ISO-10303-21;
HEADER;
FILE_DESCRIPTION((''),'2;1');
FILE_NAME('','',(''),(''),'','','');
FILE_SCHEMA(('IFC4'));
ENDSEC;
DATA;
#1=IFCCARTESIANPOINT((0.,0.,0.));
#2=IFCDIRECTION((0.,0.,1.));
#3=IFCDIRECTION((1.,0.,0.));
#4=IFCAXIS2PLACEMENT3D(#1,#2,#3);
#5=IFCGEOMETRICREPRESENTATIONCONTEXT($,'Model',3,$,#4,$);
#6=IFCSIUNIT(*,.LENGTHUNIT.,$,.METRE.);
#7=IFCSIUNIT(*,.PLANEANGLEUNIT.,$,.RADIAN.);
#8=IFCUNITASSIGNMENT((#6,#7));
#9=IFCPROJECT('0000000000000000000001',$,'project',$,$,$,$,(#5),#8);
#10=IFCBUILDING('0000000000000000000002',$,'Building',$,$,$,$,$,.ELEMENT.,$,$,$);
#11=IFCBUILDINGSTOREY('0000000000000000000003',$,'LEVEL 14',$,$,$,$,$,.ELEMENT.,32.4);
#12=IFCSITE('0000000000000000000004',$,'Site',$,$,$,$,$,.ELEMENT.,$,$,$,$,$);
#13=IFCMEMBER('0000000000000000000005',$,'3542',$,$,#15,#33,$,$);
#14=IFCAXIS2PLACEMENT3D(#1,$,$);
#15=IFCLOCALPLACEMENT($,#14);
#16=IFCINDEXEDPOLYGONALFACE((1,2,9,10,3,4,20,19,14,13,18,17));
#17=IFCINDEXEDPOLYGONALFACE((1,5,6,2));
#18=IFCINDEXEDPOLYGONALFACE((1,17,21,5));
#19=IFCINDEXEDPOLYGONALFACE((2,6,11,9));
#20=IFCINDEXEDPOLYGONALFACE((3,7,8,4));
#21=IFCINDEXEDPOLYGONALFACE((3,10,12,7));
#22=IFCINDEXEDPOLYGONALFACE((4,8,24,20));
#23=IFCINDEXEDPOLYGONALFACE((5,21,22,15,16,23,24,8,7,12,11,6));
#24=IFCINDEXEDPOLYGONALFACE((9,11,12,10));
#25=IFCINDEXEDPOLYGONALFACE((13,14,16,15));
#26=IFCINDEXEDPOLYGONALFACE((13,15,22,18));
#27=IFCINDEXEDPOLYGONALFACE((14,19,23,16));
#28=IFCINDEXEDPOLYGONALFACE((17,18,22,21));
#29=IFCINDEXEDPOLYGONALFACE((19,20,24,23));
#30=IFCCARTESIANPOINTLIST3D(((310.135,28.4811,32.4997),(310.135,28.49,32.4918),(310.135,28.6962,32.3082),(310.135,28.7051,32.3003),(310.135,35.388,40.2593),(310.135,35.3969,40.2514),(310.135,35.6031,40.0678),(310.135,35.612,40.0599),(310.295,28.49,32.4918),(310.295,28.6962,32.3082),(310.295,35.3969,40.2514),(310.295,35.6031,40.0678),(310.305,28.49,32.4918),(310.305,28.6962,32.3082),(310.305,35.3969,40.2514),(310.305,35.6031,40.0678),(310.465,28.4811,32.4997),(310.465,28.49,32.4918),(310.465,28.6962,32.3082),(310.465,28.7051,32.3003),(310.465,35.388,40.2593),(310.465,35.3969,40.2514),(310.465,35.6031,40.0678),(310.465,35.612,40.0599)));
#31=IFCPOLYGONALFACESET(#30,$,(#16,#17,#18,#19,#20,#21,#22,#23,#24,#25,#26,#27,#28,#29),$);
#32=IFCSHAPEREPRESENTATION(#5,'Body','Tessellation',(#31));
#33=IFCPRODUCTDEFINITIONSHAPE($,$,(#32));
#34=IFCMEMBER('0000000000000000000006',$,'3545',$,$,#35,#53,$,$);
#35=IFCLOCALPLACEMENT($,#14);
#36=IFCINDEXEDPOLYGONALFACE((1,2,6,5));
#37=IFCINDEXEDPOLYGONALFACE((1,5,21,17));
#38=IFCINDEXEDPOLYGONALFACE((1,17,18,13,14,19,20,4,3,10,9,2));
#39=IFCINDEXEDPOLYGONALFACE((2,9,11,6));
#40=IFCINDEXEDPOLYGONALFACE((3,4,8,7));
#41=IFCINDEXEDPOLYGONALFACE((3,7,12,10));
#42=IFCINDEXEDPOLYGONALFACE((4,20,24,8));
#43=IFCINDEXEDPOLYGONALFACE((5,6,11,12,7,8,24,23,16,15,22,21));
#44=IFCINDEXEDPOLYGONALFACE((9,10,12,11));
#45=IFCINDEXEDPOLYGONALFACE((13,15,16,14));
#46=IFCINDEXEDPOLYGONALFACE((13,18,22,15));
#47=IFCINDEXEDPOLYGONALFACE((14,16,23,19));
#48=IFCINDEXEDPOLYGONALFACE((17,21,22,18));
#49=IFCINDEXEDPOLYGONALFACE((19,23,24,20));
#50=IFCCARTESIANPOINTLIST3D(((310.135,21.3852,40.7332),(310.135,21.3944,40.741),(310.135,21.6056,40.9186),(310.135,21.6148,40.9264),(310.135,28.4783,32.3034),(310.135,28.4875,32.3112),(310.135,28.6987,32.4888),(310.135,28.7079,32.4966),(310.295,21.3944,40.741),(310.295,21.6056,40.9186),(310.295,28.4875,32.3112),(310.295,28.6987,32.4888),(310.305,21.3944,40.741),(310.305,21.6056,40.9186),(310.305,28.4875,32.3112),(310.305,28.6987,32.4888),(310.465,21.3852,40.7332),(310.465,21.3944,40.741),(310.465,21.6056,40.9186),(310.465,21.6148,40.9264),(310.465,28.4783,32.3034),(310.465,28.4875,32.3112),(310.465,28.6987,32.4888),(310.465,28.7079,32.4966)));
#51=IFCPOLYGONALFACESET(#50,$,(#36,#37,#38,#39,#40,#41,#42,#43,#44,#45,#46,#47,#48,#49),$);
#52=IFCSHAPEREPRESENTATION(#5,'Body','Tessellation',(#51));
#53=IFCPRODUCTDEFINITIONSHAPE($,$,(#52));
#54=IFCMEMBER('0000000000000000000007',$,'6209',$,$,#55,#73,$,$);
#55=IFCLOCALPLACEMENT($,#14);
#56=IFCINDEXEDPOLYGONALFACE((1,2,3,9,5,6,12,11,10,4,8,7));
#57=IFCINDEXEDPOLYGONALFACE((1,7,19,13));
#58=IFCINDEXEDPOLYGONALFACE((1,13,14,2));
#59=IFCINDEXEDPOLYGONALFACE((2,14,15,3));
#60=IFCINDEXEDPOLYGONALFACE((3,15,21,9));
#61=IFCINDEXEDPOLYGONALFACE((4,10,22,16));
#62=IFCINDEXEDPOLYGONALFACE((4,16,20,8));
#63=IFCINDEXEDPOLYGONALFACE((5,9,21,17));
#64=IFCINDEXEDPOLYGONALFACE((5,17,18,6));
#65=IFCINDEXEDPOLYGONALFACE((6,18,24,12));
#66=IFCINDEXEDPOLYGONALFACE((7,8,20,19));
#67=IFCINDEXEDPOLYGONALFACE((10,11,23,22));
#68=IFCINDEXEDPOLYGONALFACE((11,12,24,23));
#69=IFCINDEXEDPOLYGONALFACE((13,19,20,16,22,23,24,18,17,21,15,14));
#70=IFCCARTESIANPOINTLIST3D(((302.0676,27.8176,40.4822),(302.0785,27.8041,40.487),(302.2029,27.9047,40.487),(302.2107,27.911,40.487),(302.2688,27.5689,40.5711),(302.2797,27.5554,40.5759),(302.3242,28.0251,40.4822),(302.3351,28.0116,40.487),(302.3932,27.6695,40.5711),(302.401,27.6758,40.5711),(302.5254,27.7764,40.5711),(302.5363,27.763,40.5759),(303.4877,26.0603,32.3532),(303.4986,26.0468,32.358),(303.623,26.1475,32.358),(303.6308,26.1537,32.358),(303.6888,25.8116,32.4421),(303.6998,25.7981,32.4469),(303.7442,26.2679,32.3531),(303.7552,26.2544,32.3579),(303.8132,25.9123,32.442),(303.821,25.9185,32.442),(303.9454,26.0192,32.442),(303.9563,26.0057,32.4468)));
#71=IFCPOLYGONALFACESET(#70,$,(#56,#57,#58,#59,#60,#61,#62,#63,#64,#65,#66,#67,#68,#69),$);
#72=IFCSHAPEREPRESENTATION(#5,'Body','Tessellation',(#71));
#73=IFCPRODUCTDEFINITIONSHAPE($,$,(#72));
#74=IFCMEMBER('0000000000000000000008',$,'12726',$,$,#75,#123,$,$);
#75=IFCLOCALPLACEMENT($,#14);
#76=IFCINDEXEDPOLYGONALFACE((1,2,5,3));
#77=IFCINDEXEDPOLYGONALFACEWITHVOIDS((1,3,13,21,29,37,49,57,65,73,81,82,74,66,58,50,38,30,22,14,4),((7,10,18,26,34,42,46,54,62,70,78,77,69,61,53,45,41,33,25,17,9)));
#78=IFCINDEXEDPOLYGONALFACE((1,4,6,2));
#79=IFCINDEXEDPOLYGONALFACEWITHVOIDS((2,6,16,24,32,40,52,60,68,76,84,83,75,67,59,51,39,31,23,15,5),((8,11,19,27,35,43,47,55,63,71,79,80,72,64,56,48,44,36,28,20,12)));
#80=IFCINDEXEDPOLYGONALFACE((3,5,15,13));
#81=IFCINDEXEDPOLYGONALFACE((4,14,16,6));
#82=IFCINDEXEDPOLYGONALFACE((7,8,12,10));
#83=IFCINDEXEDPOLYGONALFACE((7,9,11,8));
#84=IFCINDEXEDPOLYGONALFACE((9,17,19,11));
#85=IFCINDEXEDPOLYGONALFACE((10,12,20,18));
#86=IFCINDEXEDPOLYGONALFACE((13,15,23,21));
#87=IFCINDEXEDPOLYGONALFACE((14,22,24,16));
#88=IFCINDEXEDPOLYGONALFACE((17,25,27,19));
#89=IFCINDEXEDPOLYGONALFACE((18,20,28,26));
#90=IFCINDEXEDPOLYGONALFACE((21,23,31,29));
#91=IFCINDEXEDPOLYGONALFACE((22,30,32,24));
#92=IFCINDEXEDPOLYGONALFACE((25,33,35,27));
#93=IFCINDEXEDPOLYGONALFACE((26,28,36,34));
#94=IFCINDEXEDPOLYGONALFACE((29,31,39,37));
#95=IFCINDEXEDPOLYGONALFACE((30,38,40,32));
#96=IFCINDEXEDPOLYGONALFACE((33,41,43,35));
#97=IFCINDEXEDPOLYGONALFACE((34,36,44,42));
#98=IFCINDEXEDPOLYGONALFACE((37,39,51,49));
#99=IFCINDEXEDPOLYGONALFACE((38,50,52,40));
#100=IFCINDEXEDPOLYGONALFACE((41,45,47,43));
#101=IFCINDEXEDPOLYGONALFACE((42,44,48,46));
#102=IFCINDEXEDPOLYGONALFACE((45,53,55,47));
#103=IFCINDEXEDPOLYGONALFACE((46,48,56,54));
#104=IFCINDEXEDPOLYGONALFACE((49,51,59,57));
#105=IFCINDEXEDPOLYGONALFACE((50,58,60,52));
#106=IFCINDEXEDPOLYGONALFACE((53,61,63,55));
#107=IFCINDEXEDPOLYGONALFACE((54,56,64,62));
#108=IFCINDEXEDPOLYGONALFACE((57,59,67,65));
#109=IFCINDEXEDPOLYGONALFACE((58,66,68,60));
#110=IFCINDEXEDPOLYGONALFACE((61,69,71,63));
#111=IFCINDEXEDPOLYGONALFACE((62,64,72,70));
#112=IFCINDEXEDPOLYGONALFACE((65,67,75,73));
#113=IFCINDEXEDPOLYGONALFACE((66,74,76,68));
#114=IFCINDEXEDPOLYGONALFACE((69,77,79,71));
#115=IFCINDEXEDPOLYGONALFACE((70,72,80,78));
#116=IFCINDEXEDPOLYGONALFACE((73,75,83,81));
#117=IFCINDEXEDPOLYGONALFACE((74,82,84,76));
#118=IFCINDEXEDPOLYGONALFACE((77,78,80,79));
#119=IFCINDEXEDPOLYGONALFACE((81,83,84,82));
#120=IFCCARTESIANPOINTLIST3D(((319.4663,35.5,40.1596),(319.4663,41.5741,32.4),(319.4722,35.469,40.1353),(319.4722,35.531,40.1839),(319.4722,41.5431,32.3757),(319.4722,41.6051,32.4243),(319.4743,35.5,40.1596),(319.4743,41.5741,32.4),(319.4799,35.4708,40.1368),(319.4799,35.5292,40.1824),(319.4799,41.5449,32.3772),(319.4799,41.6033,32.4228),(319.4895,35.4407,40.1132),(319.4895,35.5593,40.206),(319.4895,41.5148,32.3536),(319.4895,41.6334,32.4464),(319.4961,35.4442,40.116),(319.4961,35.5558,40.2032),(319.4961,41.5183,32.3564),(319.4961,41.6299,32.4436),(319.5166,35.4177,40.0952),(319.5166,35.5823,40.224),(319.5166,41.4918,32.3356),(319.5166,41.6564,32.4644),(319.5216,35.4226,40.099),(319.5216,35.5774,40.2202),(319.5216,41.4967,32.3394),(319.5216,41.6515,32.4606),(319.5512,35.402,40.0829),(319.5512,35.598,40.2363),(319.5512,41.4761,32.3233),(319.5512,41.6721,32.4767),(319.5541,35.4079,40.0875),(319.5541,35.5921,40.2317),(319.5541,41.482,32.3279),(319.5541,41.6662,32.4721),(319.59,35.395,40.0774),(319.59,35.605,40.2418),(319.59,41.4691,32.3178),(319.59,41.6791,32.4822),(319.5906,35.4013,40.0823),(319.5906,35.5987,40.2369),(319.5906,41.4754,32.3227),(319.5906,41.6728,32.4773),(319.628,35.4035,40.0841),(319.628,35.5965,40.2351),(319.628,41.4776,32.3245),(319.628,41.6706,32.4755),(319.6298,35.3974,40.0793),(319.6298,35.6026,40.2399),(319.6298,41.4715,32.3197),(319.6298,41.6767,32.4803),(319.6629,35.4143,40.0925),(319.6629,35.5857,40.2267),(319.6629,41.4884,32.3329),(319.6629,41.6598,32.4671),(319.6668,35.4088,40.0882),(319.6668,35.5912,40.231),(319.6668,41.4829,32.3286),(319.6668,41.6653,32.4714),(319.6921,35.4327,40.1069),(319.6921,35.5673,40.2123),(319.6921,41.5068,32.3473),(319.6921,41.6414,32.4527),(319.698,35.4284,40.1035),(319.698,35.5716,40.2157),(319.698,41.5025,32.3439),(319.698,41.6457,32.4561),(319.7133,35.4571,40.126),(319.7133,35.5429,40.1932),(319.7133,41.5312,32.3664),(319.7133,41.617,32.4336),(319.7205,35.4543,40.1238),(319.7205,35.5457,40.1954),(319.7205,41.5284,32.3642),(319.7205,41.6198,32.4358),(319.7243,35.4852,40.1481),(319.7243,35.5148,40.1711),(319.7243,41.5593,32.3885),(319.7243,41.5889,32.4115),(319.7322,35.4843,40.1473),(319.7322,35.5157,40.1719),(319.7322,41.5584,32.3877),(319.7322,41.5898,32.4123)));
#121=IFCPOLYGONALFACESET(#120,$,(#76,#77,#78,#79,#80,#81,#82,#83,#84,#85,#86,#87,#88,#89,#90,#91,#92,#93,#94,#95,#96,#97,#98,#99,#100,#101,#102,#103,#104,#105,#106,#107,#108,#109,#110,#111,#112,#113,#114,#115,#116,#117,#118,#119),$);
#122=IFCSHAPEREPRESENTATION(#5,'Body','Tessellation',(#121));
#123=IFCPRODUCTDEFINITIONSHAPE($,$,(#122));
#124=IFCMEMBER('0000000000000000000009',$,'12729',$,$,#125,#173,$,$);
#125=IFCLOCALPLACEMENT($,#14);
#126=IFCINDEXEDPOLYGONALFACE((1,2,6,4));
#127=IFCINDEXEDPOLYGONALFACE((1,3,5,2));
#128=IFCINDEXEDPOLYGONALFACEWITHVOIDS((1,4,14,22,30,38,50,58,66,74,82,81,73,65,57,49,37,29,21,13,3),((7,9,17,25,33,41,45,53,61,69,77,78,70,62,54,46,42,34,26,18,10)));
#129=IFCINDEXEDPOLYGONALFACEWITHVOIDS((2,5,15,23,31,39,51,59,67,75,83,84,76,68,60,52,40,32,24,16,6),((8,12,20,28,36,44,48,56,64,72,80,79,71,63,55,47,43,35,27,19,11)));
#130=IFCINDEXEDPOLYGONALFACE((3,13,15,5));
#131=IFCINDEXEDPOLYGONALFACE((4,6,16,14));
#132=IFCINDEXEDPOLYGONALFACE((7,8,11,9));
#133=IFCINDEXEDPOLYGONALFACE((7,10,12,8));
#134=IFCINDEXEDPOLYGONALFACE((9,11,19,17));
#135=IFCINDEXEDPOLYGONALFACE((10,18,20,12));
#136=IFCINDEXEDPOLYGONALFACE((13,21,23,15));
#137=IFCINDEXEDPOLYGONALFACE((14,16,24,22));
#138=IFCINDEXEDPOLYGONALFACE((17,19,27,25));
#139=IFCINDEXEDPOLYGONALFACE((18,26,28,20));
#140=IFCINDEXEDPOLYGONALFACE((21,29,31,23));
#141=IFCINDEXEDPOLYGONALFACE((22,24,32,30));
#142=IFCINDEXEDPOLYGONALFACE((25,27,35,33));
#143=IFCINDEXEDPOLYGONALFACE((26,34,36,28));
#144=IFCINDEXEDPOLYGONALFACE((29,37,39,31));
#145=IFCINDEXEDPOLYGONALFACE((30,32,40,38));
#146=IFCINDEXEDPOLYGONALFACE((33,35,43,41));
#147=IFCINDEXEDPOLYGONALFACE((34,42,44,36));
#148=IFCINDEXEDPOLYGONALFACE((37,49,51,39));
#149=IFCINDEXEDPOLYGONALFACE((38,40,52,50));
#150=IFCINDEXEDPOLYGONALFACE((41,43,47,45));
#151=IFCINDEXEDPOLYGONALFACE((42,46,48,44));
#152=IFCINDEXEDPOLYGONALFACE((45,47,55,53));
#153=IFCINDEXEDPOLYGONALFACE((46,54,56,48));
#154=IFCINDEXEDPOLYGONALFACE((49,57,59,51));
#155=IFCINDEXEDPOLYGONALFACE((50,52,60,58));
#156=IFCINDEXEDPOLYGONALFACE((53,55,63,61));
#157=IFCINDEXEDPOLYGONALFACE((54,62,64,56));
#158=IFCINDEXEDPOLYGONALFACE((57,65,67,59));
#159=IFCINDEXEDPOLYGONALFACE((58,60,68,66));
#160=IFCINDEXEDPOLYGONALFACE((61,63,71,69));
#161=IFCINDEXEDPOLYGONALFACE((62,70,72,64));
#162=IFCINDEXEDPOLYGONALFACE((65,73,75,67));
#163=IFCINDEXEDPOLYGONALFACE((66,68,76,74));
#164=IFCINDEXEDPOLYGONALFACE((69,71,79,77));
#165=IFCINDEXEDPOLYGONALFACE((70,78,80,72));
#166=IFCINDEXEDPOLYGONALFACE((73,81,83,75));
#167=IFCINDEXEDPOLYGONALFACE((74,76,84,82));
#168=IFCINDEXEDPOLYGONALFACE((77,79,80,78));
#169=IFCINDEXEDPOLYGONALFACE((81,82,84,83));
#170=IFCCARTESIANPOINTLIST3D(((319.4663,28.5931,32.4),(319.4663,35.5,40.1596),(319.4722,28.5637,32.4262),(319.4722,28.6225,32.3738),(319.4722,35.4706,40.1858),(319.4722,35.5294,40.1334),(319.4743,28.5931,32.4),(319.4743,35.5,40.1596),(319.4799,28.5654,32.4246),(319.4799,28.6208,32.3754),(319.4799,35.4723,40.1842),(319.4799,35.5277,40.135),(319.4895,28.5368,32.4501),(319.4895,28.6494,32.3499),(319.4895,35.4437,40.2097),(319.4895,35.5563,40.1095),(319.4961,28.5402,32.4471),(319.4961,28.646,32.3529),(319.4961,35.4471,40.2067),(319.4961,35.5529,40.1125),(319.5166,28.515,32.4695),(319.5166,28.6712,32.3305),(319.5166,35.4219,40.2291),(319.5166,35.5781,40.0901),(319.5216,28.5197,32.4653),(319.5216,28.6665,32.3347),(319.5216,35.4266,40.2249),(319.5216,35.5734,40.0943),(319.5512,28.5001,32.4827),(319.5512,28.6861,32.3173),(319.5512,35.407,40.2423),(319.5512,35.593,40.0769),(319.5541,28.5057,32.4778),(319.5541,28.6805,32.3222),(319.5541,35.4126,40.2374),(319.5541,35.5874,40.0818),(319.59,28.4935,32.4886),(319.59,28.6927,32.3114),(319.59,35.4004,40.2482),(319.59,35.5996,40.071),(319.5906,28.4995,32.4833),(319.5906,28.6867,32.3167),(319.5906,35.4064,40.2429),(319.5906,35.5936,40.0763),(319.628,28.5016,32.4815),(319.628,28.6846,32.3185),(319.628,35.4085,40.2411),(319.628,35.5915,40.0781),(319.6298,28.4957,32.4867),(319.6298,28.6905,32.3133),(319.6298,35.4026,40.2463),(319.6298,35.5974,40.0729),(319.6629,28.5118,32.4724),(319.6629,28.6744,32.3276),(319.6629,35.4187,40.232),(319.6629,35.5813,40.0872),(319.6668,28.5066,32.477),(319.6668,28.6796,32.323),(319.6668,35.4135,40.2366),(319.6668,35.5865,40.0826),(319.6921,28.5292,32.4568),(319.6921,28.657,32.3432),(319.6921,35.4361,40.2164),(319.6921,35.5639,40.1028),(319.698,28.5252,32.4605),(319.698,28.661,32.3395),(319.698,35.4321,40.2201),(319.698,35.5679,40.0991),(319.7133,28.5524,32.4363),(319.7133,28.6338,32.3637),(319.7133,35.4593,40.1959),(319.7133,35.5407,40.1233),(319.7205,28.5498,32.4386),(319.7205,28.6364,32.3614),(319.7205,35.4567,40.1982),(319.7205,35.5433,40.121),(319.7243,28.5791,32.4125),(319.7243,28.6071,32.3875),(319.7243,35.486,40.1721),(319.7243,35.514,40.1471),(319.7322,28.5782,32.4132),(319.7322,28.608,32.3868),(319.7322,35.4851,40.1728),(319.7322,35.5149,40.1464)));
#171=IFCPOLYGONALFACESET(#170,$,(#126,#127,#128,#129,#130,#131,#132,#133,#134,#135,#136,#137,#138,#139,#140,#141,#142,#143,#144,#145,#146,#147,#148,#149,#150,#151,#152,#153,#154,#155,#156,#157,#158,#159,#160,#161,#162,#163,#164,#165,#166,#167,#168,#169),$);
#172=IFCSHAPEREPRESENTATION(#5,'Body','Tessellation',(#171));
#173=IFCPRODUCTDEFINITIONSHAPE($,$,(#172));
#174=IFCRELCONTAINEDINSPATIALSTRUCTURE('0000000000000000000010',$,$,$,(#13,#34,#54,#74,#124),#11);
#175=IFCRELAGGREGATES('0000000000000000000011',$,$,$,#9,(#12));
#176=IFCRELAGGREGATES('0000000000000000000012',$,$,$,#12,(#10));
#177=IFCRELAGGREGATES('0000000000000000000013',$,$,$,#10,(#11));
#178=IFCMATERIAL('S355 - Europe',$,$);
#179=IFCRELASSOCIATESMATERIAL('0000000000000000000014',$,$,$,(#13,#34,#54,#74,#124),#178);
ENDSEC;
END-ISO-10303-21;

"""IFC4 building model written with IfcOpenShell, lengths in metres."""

from ifc_helpers import new_model, si_unit, frame, origin_with_axes, origin_2d_with_axis, place, context, project, spatial, hollow_circle, i_section, extrude, material, material_profile, profile_set, profile_usage, element, save


model = new_model("IFC4")

# Units and contexts
model_context = context("Model", 3, world=origin_with_axes())
ifc_project = project(units=[si_unit("LENGTHUNIT", "METRE"), si_unit("PLANEANGLEUNIT", "RADIAN")], contexts=[model_context])

# Site, building, storey
site = spatial("IfcSite", under=ifc_project, Name="Site", CompositionType="ELEMENT")
building = spatial("IfcBuilding", under=site, Name="Building", CompositionType="ELEMENT")
storey = spatial("IfcBuildingStorey", under=building, Name="LEVEL 14", CompositionType="ELEMENT", Elevation=32.4)

# Shared definitions
ifc_material = material(Name="S355 - Europe")

# Members
ifc_material_profile_1 = material_profile(ifc_material, i_section(OverallWidth=0.33, OverallDepth=0.3, WebThickness=0.01, FlangeThickness=0.012, at=origin_2d_with_axis()))
ifc_profile_set_1 = profile_set([ifc_material_profile_1])
ifc_profile_usage_1 = profile_usage(ifc_profile_set_1, cardinal=10)
member_1_placement = place(None, frame((310.3, 35.5, 40.1596), z_axis=(0.0, -0.664873, -0.746956), x_axis=(1.0, 0.0, 0.0)))
element("IfcMember", 1, at=member_1_placement, inside=storey, material=ifc_profile_usage_1, Name="3542", context=model_context, shape_type="SweptSolid", body=[
    extrude(i_section(OverallWidth=0.33, OverallDepth=0.3, WebThickness=0.01, FlangeThickness=0.012, at=origin_2d_with_axis()), origin_with_axes(), (0.0, 0.0, 1.0), 10.3883),
])
ifc_material_profile_2 = material_profile(ifc_material, i_section(OverallWidth=0.33, OverallDepth=0.3, WebThickness=0.01, FlangeThickness=0.012, at=origin_2d_with_axis()))
ifc_profile_set_2 = profile_set([ifc_material_profile_2])
ifc_profile_usage_2 = profile_usage(ifc_profile_set_2, cardinal=10)
member_2_placement = place(None, frame((310.3, 28.5931, 32.4), z_axis=(0.0, -0.643834, 0.765165), x_axis=(1.0, 0.0, 0.0)))
element("IfcMember", 2, at=member_2_placement, inside=storey, material=ifc_profile_usage_2, Name="3545", context=model_context, shape_type="SweptSolid", body=[
    extrude(i_section(OverallWidth=0.33, OverallDepth=0.3, WebThickness=0.01, FlangeThickness=0.012, at=origin_2d_with_axis()), origin_with_axes(), (0.0, 0.0, 1.0), 11.017),
])
ifc_material_profile_3 = material_profile(ifc_material, i_section(OverallWidth=0.33, OverallDepth=0.35, WebThickness=0.01, FlangeThickness=0.018, at=origin_2d_with_axis()))
ifc_profile_set_3 = profile_set([ifc_material_profile_3])
ifc_profile_usage_3 = profile_usage(ifc_profile_set_3, cardinal=10)
member_3_placement = place(None, frame((303.722, 26.033, 32.4), z_axis=(-0.168307, 0.208278, 0.96348), x_axis=(-0.77747, -0.62892, 0.0)))
element("IfcMember", 3, at=member_3_placement, inside=storey, material=ifc_profile_usage_3, Name="6209", context=model_context, shape_type="SweptSolid", body=[
    extrude(i_section(OverallWidth=0.33, OverallDepth=0.35, WebThickness=0.01, FlangeThickness=0.018, at=origin_2d_with_axis()), origin_with_axes(), (0.0, 0.0, 1.0), 8.4372),
])
ifc_material_profile_4 = material_profile(ifc_material, hollow_circle(Radius=0.1337, WallThickness=0.008, at=origin_2d_with_axis()))
ifc_profile_set_4 = profile_set([ifc_material_profile_4])
ifc_profile_usage_4 = profile_usage(ifc_profile_set_4, cardinal=10)
member_4_placement = place(None, frame((319.6, 35.5, 40.1596), z_axis=(0.0, 0.616394, -0.787438), x_axis=(-1.0, 0.0, 0.0)))
element("IfcMember", 4, at=member_4_placement, inside=storey, material=ifc_profile_usage_4, Name="12726", context=model_context, shape_type="SweptSolid", body=[
    extrude(hollow_circle(Radius=0.1337, WallThickness=0.008, at=origin_2d_with_axis()), origin_with_axes(), (0.0, 0.0, 1.0), 9.8542),
])
ifc_material_profile_5 = material_profile(ifc_material, hollow_circle(Radius=0.1337, WallThickness=0.008, at=origin_2d_with_axis()))
ifc_profile_set_5 = profile_set([ifc_material_profile_5])
ifc_profile_usage_5 = profile_usage(ifc_profile_set_5, cardinal=10)
member_5_placement = place(None, frame((319.6, 28.5931, 32.4), z_axis=(0.0, 0.664873, 0.746956), x_axis=(-1.0, 0.0, 0.0)))
element("IfcMember", 5, at=member_5_placement, inside=storey, material=ifc_profile_usage_5, Name="12729", context=model_context, shape_type="SweptSolid", body=[
    extrude(hollow_circle(Radius=0.1337, WallThickness=0.008, at=origin_2d_with_axis()), origin_with_axes(), (0.0, 0.0, 1.0), 10.3883),
])

save(model, "model.ifc")
